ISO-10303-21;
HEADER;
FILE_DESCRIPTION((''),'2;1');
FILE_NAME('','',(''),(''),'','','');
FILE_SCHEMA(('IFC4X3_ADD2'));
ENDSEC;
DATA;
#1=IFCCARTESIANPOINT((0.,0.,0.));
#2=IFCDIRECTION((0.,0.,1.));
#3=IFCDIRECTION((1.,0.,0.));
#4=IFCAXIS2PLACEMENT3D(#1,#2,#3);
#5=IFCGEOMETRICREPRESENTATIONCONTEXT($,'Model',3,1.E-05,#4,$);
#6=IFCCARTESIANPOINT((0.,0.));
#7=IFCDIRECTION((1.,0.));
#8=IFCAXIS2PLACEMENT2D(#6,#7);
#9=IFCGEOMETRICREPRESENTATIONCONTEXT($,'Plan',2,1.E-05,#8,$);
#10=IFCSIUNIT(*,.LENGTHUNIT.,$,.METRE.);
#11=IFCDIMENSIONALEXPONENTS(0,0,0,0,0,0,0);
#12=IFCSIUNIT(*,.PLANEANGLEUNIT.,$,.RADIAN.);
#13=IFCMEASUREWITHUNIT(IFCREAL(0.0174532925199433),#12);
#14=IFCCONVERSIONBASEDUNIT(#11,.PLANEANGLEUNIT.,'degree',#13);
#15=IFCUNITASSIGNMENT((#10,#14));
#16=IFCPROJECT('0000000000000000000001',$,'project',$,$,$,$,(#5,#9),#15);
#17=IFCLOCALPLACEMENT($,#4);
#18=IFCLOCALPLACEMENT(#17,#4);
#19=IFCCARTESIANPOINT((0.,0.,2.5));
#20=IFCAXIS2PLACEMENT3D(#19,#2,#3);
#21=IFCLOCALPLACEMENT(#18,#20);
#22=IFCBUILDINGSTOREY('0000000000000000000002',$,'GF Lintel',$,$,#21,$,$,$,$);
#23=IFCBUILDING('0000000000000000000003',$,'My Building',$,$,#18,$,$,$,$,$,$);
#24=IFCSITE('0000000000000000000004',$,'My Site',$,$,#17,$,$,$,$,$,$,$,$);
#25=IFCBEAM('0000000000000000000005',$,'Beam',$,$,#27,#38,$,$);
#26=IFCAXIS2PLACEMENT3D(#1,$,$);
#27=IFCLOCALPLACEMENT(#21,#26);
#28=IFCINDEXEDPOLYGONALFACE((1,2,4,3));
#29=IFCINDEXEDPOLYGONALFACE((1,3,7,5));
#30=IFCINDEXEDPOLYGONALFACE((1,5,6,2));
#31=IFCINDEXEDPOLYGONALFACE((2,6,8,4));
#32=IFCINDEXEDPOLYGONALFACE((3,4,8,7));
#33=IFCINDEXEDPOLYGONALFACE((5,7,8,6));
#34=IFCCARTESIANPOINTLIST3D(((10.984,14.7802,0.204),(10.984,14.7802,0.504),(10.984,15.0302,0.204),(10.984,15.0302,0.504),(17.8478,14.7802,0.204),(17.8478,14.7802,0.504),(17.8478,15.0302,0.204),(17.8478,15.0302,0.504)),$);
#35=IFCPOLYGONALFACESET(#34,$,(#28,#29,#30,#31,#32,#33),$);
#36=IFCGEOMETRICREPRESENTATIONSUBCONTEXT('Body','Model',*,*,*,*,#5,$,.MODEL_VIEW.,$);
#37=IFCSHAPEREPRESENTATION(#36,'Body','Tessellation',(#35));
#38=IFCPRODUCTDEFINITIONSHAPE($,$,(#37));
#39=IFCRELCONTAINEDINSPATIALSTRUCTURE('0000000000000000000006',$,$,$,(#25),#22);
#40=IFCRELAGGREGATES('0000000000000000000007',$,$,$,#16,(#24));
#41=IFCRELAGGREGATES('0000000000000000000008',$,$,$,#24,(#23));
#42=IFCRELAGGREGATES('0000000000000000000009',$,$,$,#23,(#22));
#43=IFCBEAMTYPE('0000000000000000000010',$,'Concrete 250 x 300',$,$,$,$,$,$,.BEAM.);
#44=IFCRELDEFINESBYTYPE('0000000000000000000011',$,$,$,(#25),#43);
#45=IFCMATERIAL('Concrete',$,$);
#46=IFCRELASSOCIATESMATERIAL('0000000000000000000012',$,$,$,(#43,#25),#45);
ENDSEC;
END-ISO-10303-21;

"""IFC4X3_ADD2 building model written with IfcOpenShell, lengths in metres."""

from ifc_helpers import new_model, entity, si_unit, converted_unit, frame, origin_with_axes, origin_2d_with_axis, place, context, subcontext, project, spatial, rectangle, extrude, material, material_profile, profile_set, profile_usage, type_object, element, save


model = new_model("IFC4X3_ADD2")

# Units and contexts
model_context = context("Model", 3, precision=1e-05, world=origin_with_axes())
plan_context = context("Plan", 2, precision=1e-05, world=origin_2d_with_axis())
body_context = subcontext(model_context, "Body", "Model", "MODEL_VIEW")
ifc_project = project(units=[si_unit("LENGTHUNIT", "METRE"), converted_unit("PLANEANGLEUNIT", "degree", entity("IfcReal", 0.0174532925199433), si_unit("PLANEANGLEUNIT", "RADIAN"), dimensions=[0, 0, 0, 0, 0, 0, 0])], contexts=[model_context, plan_context])

# Site, building, storey
site_placement = place(None, origin_with_axes())
site = spatial("IfcSite", under=ifc_project, at=site_placement, Name="My Site")
building_placement = place(site_placement, origin_with_axes())
building = spatial("IfcBuilding", under=site, at=building_placement, Name="My Building")
storey_placement = place(building_placement, frame((0.0, 0.0, 2.5), z_axis=(0.0, 0.0, 1.0), x_axis=(1.0, 0.0, 0.0)))
storey = spatial("IfcBuildingStorey", under=building, at=storey_placement, Name="GF Lintel")

# Beam
ifc_material = material(Name="Concrete")
ifc_material_profile = material_profile(ifc_material, rectangle(XDim=0.25, YDim=0.3))
ifc_profile_set = profile_set([ifc_material_profile])
ifc_profile_usage = profile_usage(ifc_profile_set, cardinal=5)
beam_type = type_object("IfcBeamType", Name="Concrete 250 x 300", PredefinedType="BEAM", material=ifc_profile_set)
beam_placement = place(storey_placement, frame((10.984, 14.9052, 0.354), z_axis=(1.0, 0.0, 0.0), x_axis=(0.0, 1.0, 0.0)))
element("IfcBeam", 1, at=beam_placement, inside=storey, type_object=beam_type, material=ifc_profile_usage, Name="Beam", context=body_context, shape_type="SweptSolid", body=[
    extrude(rectangle(XDim=0.25, YDim=0.3), origin_with_axes(), (0.0, 0.0, 1.0), 6.8638),
])

save(model, "model.ifc")
